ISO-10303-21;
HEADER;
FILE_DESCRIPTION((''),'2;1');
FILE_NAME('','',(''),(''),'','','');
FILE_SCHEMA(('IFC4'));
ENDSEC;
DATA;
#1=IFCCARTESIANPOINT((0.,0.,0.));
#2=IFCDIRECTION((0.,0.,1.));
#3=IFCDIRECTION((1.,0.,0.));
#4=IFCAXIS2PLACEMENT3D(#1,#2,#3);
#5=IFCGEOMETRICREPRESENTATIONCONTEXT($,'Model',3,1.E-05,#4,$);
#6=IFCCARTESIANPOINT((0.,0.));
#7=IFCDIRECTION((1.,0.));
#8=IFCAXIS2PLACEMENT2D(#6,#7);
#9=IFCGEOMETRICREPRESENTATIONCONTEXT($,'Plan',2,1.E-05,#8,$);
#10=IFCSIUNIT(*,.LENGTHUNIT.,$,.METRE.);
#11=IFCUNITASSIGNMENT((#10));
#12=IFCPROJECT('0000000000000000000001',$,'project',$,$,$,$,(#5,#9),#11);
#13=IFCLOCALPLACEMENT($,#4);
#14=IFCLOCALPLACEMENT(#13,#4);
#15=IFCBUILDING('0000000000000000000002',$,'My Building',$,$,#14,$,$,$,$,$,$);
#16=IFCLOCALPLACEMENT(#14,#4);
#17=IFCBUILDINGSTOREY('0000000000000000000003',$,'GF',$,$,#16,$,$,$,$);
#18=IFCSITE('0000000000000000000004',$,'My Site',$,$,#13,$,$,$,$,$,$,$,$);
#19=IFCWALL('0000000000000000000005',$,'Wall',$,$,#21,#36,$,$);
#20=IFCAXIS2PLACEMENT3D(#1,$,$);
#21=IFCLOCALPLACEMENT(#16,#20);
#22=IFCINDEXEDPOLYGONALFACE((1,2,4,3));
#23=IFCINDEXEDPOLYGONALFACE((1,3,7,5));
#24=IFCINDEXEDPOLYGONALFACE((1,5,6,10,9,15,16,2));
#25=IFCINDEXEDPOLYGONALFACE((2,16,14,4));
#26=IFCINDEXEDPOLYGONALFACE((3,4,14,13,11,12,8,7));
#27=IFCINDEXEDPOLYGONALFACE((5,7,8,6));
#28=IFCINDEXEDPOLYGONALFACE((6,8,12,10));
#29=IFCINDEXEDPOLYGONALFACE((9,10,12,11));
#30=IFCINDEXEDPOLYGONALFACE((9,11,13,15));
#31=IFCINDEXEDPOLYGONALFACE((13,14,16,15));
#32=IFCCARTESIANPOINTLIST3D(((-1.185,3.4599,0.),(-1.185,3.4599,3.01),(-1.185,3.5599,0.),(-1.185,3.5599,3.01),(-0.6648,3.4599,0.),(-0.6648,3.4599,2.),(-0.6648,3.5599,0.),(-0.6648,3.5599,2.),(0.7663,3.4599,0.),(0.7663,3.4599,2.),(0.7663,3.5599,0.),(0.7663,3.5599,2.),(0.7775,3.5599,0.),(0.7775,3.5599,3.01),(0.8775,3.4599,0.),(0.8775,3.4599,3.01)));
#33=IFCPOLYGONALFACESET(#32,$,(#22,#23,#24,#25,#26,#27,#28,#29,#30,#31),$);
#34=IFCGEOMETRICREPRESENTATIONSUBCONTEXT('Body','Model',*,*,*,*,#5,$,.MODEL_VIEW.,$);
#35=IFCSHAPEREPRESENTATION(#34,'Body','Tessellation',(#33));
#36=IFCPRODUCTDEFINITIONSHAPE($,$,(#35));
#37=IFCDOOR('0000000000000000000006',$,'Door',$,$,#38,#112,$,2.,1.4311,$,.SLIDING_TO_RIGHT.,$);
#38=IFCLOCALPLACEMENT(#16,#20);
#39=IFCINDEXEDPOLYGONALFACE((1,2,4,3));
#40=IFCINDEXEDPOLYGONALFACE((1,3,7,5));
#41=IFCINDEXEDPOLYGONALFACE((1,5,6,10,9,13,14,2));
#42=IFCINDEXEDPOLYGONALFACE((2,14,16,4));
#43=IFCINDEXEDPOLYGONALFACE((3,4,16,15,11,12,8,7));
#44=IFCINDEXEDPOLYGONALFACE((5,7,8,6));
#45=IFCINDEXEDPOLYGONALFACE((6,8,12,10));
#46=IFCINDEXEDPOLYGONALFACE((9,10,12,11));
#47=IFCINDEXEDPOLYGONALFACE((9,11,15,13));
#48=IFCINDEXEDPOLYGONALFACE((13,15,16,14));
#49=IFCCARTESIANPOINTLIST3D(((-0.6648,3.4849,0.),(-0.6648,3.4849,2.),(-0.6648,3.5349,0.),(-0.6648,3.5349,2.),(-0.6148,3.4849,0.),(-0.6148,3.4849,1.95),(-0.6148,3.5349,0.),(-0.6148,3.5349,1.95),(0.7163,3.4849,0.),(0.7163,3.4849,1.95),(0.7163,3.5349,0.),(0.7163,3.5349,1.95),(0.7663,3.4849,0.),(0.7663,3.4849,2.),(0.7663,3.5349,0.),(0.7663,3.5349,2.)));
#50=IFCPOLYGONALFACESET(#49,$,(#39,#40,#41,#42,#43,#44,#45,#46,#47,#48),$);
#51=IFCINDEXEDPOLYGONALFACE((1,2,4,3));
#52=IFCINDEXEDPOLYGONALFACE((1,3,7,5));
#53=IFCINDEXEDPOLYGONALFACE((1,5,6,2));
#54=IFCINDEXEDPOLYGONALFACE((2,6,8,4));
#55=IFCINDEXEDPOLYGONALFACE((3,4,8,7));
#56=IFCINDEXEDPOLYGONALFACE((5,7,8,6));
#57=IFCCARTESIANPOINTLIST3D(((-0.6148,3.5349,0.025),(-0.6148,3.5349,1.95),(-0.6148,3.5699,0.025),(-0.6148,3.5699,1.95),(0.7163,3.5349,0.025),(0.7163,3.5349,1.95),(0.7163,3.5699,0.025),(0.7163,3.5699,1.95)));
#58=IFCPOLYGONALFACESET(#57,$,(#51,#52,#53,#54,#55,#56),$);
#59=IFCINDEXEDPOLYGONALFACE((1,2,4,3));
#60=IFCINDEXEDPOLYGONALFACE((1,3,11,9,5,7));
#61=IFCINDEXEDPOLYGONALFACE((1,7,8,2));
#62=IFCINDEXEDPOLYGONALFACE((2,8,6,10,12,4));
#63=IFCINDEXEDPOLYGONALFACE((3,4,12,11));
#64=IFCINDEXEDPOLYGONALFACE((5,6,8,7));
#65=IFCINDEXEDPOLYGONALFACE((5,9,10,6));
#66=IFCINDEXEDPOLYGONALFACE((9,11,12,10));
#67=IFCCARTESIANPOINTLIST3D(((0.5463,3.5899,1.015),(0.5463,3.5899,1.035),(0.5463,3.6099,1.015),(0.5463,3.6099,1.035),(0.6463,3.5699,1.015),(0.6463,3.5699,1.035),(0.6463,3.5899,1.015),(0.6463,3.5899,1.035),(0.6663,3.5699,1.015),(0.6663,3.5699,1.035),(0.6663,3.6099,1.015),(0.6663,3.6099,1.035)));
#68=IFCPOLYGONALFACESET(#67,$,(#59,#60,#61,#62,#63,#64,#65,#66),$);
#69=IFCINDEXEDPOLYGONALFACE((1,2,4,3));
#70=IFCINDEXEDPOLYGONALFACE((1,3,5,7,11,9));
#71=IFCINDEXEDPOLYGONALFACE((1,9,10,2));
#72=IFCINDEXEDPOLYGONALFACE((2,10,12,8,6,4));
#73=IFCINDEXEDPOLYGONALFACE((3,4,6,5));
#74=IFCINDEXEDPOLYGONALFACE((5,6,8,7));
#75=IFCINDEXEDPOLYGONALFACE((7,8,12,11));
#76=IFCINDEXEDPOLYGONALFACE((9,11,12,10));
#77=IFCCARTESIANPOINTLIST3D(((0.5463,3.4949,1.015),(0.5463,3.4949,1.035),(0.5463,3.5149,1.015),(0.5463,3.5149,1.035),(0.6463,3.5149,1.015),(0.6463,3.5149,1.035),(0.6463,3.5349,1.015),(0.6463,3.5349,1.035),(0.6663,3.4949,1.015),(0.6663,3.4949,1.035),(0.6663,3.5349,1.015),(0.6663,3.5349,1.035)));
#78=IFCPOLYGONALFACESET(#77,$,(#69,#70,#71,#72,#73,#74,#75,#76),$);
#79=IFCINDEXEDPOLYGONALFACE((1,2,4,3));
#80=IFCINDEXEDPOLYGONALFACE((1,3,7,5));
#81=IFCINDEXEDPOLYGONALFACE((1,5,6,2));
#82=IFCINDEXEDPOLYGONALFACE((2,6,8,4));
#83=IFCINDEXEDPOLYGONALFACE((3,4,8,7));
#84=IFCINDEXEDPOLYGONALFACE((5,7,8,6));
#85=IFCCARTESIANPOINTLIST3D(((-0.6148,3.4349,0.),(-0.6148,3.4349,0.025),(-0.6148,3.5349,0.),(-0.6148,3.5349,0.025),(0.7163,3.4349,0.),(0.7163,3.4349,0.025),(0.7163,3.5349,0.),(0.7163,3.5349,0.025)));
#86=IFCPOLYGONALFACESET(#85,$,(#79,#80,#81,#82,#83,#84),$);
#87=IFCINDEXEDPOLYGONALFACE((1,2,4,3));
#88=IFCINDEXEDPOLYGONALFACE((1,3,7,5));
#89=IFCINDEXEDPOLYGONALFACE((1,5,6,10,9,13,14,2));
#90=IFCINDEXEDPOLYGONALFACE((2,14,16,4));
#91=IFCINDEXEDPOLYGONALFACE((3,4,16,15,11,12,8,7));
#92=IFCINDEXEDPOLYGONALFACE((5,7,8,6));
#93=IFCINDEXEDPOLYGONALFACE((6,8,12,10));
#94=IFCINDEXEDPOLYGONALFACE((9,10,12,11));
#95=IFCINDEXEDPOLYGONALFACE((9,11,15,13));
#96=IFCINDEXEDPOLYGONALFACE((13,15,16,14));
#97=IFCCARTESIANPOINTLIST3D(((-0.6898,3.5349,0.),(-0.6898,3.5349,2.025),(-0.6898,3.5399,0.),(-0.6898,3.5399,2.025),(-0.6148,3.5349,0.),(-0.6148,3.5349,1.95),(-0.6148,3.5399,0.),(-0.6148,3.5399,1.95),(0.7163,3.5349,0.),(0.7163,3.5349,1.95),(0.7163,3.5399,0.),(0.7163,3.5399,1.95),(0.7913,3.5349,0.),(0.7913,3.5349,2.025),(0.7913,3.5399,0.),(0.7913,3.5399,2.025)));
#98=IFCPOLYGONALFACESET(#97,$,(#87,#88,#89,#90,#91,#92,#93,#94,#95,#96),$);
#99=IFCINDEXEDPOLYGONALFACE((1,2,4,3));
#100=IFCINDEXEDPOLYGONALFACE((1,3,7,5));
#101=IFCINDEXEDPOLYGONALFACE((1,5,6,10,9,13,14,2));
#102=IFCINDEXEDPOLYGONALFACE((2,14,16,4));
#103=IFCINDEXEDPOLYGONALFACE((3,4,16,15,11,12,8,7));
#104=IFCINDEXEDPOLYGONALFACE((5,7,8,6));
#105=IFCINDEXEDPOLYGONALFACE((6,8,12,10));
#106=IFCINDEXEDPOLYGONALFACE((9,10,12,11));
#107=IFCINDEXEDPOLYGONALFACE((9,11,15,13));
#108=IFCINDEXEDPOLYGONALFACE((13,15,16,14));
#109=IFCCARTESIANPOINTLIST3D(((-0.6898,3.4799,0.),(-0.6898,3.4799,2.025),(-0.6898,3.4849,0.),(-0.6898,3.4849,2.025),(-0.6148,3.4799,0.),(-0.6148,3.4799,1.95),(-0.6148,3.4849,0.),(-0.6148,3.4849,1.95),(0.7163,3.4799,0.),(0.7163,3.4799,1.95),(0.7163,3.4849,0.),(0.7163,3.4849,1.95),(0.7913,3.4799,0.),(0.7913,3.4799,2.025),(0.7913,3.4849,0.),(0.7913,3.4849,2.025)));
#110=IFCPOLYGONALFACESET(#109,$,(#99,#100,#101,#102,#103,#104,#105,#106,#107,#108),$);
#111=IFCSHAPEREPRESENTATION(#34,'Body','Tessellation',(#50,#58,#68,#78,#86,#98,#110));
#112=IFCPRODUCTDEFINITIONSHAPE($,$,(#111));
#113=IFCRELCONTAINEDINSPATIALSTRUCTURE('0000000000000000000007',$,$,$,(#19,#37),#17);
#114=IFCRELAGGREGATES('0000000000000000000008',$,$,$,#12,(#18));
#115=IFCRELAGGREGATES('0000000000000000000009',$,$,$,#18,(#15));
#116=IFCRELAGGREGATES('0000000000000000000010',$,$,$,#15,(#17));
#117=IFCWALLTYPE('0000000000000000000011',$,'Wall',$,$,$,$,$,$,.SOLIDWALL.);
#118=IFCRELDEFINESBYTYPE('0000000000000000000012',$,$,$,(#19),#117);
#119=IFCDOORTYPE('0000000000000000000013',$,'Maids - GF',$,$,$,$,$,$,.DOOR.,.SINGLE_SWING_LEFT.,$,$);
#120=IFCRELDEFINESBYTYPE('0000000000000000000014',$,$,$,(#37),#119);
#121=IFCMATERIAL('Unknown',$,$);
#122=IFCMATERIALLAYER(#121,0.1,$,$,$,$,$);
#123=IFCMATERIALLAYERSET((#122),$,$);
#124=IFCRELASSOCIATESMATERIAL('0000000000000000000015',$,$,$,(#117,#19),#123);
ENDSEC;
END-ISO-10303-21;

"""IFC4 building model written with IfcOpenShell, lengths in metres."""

from ifc_helpers import new_model, entity, si_unit, frame, origin_with_axes, origin_2d_with_axis, place, context, subcontext, project, spatial, line, indexed_curve, outline, extrude, shape, source, transform, mapped, material, layer, layer_set, layer_usage, type_object, type_shapes, element, fill, save


model = new_model("IFC4")

# Units and contexts
model_context = context("Model", 3, precision=1e-05, world=origin_with_axes())
plan_context = context("Plan", 2, precision=1e-05, world=origin_2d_with_axis())
body_context_1 = subcontext(model_context, "Body", "Model", "MODEL_VIEW")
body_context_2 = subcontext(plan_context, "Body", "Plan", "PLAN_VIEW")
ifc_project = project(units=[si_unit("LENGTHUNIT", "METRE")], contexts=[model_context, plan_context])

# Site, building, storey
site_placement = place(None, origin_with_axes())
site = spatial("IfcSite", under=ifc_project, at=site_placement, Name="My Site")
building_placement = place(site_placement, origin_with_axes())
building = spatial("IfcBuilding", under=site, at=building_placement, Name="My Building")
storey_placement = place(building_placement, origin_with_axes())
storey = spatial("IfcBuildingStorey", under=building, at=storey_placement, Name="GF")

# Shared definitions
ifc_material = material(Name="Unknown")

# Shared definitions
ifc_layer_1 = layer(ifc_material, 0.1)
ifc_layer_set_1 = layer_set([ifc_layer_1])
wall_type = type_object("IfcWallType", Name="Wall", PredefinedType="SOLIDWALL", material=ifc_layer_set_1)

# Wall, opening, door
ifc_layer_usage_1 = layer_usage(ifc_layer_set_1, "AXIS2", "POSITIVE", 0.0)
wall_1_placement = place(storey_placement, frame((0.7775, 3.5599, 0.0), z_axis=(0.0, 0.0, 1.0), x_axis=(-1.0, 0.0, 0.0)))
wall_1 = element("IfcWall", 1, at=wall_1_placement, inside=storey, type_object=wall_type, material=ifc_layer_usage_1, Name="Wall", context=body_context_1, shape_type="SweptSolid", body=[
    extrude(outline(indexed_curve([(0.0, 0.0), (-0.1, 0.1), (1.9625, 0.1), (1.9625, 0.0)], segments=[line(1, 2, 3, 4, 1)])), origin_with_axes(), (0.0, 0.0, 1.0), 3.01),
])
shared_shape_1 = source(origin_with_axes(), body_context_1, "Body", "SweptSolid", [
    extrude(outline(indexed_curve([(0.0, 0.0), (1.4311, 0.0), (1.4311, 2.0), (0.0, 2.0)], segments=[line(1, 2, 3, 4, 1)])), frame((0.0, -0.6, 0.0), z_axis=(0.0, -1.0, 0.0), x_axis=(1.0, 0.0, 0.0)), (0.0, 0.0, -1.0), 1.2),
])
opening_1_placement = place(wall_1_placement, frame((0.0111, 0.025, 0.0), z_axis=(0.0, 0.0, 1.0), x_axis=(1.0, -0.000001, 0.0)))
opening_1 = element("IfcOpeningElement", 2, at=opening_1_placement, cuts=wall_1, PredefinedType="OPENING", context=body_context_1, shape_type="MappedRepresentation", body=[
    mapped(shared_shape_1, transform((0.0, 0.0, 0.0), x_axis=(1.0, 0.0, 0.0), y_axis=(0.0, 1.0, 0.0), z_axis=(0.0, 0.0, 1.0), scale=1.0)),
])
door_type_1 = type_object("IfcDoorType", Name="Maids - GF", OperationType="SINGLE_SWING_LEFT", PredefinedType="DOOR")
shared_shape_2 = source(origin_with_axes(), body_context_1, "Body", "SweptSolid", [
    extrude(outline(indexed_curve([(0.0, 0.0), (0.0, 2.0), (1.4311, 2.0), (1.4311, 0.0), (1.3811, 0.0), (1.3811, 1.95), (0.05, 1.95), (0.05, 0.0)], segments=[line(1, 2, 3, 4, 5, 6, 7, 8, 1)])), frame((0.0, 0.0, 0.0), z_axis=(0.0, -1.0, 0.0), x_axis=(1.0, 0.0, 0.0)), (0.0, 0.0, -1.0), 0.05),
    extrude(outline(indexed_curve([(0.0, 0.0), (1.3311, 0.0), (1.3311, 0.035), (0.0, 0.035)], segments=[line(1, 2, 3, 4, 1)])), frame((0.05, -0.035, 0.025), z_axis=(0.0, 0.0, 1.0), x_axis=(1.0, 0.0, 0.0)), (0.0, 0.0, 1.0), 1.925),
    extrude(outline(indexed_curve([(0.0, 0.0), (0.0, -0.04), (0.12, -0.04), (0.12, -0.02), (0.02, -0.02), (0.02, 0.0)], segments=[line(1, 2, 3, 4, 5, 6, 1)])), frame((0.1, -0.035, 1.015), z_axis=(0.0, 0.0, 1.0), x_axis=(1.0, 0.0, 0.0)), (0.0, 0.0, 1.0), 0.02),
    extrude(outline(indexed_curve([(0.0, 0.0), (0.0, 0.04), (0.12, 0.04), (0.12, 0.02), (0.02, 0.02), (0.02, 0.0)], segments=[line(1, 2, 3, 4, 5, 6, 1)])), frame((0.1, 0.0, 1.015), z_axis=(0.0, 0.0, 1.0), x_axis=(1.0, 0.0, 0.0)), (0.0, 0.0, 1.0), 0.02),
    extrude(outline(indexed_curve([(0.0, 0.0), (1.3311, 0.0), (1.3311, 0.1), (0.0, 0.1)], segments=[line(1, 2, 3, 4, 1)])), frame((0.05, 0.0, 0.0), z_axis=(0.0, 0.0, 1.0), x_axis=(1.0, 0.0, 0.0)), (0.0, 0.0, 1.0), 0.025),
    extrude(outline(indexed_curve([(0.0, 0.0), (0.0, 2.025), (1.4811, 2.025), (1.4811, 0.0), (1.4061, 0.0), (1.4061, 1.95), (0.075, 1.95), (0.075, 0.0)], segments=[line(1, 2, 3, 4, 5, 6, 7, 8, 1)])), frame((-0.025, -0.005, 0.0), z_axis=(0.0, -1.0, 0.0), x_axis=(1.0, 0.0, 0.0)), (0.0, 0.0, -1.0), 0.005),
    extrude(outline(indexed_curve([(0.0, 0.0), (0.0, 2.025), (1.4811, 2.025), (1.4811, 0.0), (1.4061, 0.0), (1.4061, 1.95), (0.075, 1.95), (0.075, 0.0)], segments=[line(1, 2, 3, 4, 5, 6, 7, 8, 1)])), frame((-0.025, 0.05, 0.0), z_axis=(0.0, -1.0, 0.0), x_axis=(1.0, 0.0, 0.0)), (0.0, 0.0, -1.0), 0.005),
])
shared_shape_3 = source(origin_with_axes(), body_context_2, "Body", "Curve2D", [
    entity("IfcIndexedPolyCurve", entity("IfcCartesianPointList2D", [[0.0, 0.0], [0.05, 0.0], [0.05, 0.05], [0.0, 0.05]]), [entity("IfcLineIndex", [1, 2, 3, 4, 1])]),
    entity("IfcIndexedPolyCurve", entity("IfcCartesianPointList2D", [[1.4311, 0.0], [1.3811, 0.0], [1.3811, 0.05], [1.4311, 0.05]]), [entity("IfcLineIndex", [1, 2, 3, 4, 1])]),
    entity("IfcIndexedPolyCurve", entity("IfcCartesianPointList2D", [[2.0467, -0.035], [0.7156, -0.035], [0.7156, 0.0], [2.0467, 0.0]]), [entity("IfcLineIndex", [1, 2, 3, 4, 1])]),
])
type_shapes(door_type_1, [shared_shape_2, shared_shape_3])
door_1_placement = place(opening_1_placement, frame((0.0, 0.0, 0.0), z_axis=(0.0, 0.0, 1.0), x_axis=(1.0, 0.0, 0.0)))
door_1 = element("IfcDoor", 3, at=door_1_placement, inside=storey, type_object=door_type_1, Name="Door", OperationType="SLIDING_TO_RIGHT", OverallHeight=2.0, OverallWidth=1.4311, shapes=[
    shape(body_context_1, "Body", "MappedRepresentation", [mapped(shared_shape_2, transform((0.0, 0.0, 0.0), x_axis=(1.0, 0.0, 0.0), y_axis=(0.0, 1.0, 0.0), z_axis=(0.0, 0.0, 1.0), scale=1.0))]),
    shape(body_context_2, "Body", "MappedRepresentation", [mapped(shared_shape_3, transform((0.0, 0.0, 0.0), x_axis=(1.0, 0.0, 0.0), y_axis=(0.0, 1.0, 0.0), z_axis=(0.0, 0.0, 1.0), scale=1.0))]),
])
fill(opening_1, door_1)

save(model, "model.ifc")
